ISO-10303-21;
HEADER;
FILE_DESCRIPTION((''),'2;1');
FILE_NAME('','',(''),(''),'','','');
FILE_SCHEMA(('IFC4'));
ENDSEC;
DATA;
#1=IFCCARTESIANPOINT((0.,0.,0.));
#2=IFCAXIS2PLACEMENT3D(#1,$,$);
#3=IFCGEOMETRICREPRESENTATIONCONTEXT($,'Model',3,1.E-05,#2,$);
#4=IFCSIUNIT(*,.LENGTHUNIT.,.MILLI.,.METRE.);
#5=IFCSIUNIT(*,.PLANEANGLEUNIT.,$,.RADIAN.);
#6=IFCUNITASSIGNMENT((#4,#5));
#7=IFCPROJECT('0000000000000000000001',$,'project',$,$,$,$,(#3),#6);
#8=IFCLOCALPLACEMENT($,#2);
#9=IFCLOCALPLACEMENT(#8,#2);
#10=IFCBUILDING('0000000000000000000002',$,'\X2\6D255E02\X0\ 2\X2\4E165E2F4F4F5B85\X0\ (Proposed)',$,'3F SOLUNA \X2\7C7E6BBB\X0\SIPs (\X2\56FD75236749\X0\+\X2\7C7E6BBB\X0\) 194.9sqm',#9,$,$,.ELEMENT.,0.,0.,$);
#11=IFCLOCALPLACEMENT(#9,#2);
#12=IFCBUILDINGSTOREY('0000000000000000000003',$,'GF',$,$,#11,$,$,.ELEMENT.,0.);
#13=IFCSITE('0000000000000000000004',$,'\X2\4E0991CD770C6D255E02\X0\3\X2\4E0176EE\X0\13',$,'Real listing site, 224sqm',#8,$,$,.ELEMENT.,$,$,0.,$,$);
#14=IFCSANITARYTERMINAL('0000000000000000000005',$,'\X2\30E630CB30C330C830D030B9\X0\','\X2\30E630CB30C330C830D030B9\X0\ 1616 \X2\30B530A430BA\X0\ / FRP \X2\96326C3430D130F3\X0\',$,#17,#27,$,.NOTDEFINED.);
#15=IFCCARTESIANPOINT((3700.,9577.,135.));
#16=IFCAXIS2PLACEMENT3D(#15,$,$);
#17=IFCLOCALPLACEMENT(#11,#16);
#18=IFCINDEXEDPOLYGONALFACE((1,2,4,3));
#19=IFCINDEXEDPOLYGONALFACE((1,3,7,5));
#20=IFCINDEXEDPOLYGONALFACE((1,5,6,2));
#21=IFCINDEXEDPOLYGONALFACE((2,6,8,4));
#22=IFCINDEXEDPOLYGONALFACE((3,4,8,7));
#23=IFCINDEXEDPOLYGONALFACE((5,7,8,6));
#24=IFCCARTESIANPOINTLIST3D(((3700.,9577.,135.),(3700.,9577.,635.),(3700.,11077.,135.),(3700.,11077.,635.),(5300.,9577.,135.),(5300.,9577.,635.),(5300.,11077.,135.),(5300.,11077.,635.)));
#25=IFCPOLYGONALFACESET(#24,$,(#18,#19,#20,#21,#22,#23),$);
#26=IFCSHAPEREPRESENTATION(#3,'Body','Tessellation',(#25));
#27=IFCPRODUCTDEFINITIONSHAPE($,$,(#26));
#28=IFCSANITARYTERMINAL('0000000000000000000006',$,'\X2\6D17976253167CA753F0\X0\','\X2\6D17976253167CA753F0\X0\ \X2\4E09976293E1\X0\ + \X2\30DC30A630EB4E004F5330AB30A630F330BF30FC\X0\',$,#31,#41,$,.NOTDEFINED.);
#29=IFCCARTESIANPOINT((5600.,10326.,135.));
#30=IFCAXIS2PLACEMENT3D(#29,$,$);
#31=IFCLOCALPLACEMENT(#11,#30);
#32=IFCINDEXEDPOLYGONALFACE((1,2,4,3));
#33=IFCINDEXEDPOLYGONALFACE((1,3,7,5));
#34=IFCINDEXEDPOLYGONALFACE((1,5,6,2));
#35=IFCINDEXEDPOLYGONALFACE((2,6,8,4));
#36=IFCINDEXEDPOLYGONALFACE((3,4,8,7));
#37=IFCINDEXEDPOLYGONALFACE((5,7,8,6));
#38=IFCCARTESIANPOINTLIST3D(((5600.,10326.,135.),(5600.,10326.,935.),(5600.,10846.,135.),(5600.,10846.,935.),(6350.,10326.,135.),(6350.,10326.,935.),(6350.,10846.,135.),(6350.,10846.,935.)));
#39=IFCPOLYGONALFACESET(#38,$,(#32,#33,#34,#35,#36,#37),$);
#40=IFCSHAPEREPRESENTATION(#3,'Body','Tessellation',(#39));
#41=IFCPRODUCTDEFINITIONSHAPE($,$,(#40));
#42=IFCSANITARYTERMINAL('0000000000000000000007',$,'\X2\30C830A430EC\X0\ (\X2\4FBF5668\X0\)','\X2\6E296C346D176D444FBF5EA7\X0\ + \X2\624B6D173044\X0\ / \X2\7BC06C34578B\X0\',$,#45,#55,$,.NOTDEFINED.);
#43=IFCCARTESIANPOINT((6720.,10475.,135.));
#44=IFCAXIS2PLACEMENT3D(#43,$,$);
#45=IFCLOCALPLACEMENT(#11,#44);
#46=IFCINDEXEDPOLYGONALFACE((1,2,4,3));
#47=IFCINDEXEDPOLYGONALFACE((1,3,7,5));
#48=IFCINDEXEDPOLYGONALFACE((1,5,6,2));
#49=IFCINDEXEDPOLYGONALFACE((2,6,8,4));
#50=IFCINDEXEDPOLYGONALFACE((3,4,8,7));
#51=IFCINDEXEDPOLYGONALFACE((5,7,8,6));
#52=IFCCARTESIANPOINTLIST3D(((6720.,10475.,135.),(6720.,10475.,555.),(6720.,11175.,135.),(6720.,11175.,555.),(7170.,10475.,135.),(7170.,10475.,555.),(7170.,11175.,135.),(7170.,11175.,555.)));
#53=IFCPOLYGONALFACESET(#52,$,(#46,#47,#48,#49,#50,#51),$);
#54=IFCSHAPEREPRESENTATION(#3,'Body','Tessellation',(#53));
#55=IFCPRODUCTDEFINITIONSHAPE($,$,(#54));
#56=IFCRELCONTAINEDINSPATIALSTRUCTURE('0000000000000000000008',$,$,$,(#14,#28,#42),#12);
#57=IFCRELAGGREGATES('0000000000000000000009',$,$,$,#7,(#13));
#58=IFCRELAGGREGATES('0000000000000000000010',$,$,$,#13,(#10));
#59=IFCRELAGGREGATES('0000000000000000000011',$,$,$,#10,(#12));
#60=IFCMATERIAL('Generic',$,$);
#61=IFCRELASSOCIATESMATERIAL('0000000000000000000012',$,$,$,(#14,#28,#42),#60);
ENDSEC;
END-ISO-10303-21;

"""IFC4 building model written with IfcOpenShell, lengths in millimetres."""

from ifc_helpers import new_model, si_unit, frame, frame_2d, origin, place, context, project, spatial, rectangle, extrude, material, element, save


model = new_model("IFC4")

# Units and contexts
model_context = context("Model", 3, precision=1e-05, world=origin())
ifc_project = project(units=[si_unit("LENGTHUNIT", "METRE", prefix="MILLI"), si_unit("PLANEANGLEUNIT", "RADIAN")], contexts=[model_context])

# Site, building, storey
site_placement = place(None, origin())
site = spatial("IfcSite", under=ifc_project, at=site_placement, Name="三重県津市3丁目13", ObjectType="Real listing site, 224sqm", CompositionType="ELEMENT", RefElevation=0.0)
building_placement = place(site_placement, origin())
building = spatial("IfcBuilding", under=site, at=building_placement, Name="津市 2世帯住宅 (Proposed)", ObjectType="3F SOLUNA 籾殻SIPs (国産杉+籾殻) 194.9sqm", CompositionType="ELEMENT", ElevationOfRefHeight=0.0, ElevationOfTerrain=0.0)
storey_placement = place(building_placement, origin())
storey = spatial("IfcBuildingStorey", under=building, at=storey_placement, Name="GF", CompositionType="ELEMENT", Elevation=0.0)

# Shared definitions
ifc_material_1 = material(Name="Generic")

# Sanitary terminals
sanitary_terminal_1_placement = place(storey_placement, frame((3700.0, 9577.0, 135.0)))
element("IfcSanitaryTerminal", 1, at=sanitary_terminal_1_placement, inside=storey, material=ifc_material_1, Name="ユニットバス", Description="ユニットバス 1616 サイズ / FRP 防水パン", PredefinedType="NOTDEFINED", context=model_context, shape_type="SweptSolid", body=[
    extrude(rectangle(XDim=1600.0, YDim=1500.0, at=frame_2d((800.0, 750.0))), frame((3700.0, 9577.0, 135.0)), (0.0, 0.0, 1.0), 500.0),
])
sanitary_terminal_2_placement = place(storey_placement, frame((5600.0, 10326.0, 135.0)))
element("IfcSanitaryTerminal", 2, at=sanitary_terminal_2_placement, inside=storey, material=ifc_material_1, Name="洗面化粧台", Description="洗面化粧台 三面鏡 + ボウル一体カウンター", PredefinedType="NOTDEFINED", context=model_context, shape_type="SweptSolid", body=[
    extrude(rectangle(XDim=750.0, YDim=520.0, at=frame_2d((375.0, 260.0))), frame((5600.0, 10326.0, 135.0)), (0.0, 0.0, 1.0), 800.0),
])
sanitary_terminal_3_placement = place(storey_placement, frame((6720.0, 10475.0, 135.0)))
element("IfcSanitaryTerminal", 3, at=sanitary_terminal_3_placement, inside=storey, material=ifc_material_1, Name="トイレ (便器)", Description="温水洗浄便座 + 手洗い / 節水型", PredefinedType="NOTDEFINED", context=model_context, shape_type="SweptSolid", body=[
    extrude(rectangle(XDim=450.0, YDim=700.0, at=frame_2d((225.0, 350.0))), frame((6720.0, 10475.0, 135.0)), (0.0, 0.0, 1.0), 420.0),
])

save(model, "model.ifc")
